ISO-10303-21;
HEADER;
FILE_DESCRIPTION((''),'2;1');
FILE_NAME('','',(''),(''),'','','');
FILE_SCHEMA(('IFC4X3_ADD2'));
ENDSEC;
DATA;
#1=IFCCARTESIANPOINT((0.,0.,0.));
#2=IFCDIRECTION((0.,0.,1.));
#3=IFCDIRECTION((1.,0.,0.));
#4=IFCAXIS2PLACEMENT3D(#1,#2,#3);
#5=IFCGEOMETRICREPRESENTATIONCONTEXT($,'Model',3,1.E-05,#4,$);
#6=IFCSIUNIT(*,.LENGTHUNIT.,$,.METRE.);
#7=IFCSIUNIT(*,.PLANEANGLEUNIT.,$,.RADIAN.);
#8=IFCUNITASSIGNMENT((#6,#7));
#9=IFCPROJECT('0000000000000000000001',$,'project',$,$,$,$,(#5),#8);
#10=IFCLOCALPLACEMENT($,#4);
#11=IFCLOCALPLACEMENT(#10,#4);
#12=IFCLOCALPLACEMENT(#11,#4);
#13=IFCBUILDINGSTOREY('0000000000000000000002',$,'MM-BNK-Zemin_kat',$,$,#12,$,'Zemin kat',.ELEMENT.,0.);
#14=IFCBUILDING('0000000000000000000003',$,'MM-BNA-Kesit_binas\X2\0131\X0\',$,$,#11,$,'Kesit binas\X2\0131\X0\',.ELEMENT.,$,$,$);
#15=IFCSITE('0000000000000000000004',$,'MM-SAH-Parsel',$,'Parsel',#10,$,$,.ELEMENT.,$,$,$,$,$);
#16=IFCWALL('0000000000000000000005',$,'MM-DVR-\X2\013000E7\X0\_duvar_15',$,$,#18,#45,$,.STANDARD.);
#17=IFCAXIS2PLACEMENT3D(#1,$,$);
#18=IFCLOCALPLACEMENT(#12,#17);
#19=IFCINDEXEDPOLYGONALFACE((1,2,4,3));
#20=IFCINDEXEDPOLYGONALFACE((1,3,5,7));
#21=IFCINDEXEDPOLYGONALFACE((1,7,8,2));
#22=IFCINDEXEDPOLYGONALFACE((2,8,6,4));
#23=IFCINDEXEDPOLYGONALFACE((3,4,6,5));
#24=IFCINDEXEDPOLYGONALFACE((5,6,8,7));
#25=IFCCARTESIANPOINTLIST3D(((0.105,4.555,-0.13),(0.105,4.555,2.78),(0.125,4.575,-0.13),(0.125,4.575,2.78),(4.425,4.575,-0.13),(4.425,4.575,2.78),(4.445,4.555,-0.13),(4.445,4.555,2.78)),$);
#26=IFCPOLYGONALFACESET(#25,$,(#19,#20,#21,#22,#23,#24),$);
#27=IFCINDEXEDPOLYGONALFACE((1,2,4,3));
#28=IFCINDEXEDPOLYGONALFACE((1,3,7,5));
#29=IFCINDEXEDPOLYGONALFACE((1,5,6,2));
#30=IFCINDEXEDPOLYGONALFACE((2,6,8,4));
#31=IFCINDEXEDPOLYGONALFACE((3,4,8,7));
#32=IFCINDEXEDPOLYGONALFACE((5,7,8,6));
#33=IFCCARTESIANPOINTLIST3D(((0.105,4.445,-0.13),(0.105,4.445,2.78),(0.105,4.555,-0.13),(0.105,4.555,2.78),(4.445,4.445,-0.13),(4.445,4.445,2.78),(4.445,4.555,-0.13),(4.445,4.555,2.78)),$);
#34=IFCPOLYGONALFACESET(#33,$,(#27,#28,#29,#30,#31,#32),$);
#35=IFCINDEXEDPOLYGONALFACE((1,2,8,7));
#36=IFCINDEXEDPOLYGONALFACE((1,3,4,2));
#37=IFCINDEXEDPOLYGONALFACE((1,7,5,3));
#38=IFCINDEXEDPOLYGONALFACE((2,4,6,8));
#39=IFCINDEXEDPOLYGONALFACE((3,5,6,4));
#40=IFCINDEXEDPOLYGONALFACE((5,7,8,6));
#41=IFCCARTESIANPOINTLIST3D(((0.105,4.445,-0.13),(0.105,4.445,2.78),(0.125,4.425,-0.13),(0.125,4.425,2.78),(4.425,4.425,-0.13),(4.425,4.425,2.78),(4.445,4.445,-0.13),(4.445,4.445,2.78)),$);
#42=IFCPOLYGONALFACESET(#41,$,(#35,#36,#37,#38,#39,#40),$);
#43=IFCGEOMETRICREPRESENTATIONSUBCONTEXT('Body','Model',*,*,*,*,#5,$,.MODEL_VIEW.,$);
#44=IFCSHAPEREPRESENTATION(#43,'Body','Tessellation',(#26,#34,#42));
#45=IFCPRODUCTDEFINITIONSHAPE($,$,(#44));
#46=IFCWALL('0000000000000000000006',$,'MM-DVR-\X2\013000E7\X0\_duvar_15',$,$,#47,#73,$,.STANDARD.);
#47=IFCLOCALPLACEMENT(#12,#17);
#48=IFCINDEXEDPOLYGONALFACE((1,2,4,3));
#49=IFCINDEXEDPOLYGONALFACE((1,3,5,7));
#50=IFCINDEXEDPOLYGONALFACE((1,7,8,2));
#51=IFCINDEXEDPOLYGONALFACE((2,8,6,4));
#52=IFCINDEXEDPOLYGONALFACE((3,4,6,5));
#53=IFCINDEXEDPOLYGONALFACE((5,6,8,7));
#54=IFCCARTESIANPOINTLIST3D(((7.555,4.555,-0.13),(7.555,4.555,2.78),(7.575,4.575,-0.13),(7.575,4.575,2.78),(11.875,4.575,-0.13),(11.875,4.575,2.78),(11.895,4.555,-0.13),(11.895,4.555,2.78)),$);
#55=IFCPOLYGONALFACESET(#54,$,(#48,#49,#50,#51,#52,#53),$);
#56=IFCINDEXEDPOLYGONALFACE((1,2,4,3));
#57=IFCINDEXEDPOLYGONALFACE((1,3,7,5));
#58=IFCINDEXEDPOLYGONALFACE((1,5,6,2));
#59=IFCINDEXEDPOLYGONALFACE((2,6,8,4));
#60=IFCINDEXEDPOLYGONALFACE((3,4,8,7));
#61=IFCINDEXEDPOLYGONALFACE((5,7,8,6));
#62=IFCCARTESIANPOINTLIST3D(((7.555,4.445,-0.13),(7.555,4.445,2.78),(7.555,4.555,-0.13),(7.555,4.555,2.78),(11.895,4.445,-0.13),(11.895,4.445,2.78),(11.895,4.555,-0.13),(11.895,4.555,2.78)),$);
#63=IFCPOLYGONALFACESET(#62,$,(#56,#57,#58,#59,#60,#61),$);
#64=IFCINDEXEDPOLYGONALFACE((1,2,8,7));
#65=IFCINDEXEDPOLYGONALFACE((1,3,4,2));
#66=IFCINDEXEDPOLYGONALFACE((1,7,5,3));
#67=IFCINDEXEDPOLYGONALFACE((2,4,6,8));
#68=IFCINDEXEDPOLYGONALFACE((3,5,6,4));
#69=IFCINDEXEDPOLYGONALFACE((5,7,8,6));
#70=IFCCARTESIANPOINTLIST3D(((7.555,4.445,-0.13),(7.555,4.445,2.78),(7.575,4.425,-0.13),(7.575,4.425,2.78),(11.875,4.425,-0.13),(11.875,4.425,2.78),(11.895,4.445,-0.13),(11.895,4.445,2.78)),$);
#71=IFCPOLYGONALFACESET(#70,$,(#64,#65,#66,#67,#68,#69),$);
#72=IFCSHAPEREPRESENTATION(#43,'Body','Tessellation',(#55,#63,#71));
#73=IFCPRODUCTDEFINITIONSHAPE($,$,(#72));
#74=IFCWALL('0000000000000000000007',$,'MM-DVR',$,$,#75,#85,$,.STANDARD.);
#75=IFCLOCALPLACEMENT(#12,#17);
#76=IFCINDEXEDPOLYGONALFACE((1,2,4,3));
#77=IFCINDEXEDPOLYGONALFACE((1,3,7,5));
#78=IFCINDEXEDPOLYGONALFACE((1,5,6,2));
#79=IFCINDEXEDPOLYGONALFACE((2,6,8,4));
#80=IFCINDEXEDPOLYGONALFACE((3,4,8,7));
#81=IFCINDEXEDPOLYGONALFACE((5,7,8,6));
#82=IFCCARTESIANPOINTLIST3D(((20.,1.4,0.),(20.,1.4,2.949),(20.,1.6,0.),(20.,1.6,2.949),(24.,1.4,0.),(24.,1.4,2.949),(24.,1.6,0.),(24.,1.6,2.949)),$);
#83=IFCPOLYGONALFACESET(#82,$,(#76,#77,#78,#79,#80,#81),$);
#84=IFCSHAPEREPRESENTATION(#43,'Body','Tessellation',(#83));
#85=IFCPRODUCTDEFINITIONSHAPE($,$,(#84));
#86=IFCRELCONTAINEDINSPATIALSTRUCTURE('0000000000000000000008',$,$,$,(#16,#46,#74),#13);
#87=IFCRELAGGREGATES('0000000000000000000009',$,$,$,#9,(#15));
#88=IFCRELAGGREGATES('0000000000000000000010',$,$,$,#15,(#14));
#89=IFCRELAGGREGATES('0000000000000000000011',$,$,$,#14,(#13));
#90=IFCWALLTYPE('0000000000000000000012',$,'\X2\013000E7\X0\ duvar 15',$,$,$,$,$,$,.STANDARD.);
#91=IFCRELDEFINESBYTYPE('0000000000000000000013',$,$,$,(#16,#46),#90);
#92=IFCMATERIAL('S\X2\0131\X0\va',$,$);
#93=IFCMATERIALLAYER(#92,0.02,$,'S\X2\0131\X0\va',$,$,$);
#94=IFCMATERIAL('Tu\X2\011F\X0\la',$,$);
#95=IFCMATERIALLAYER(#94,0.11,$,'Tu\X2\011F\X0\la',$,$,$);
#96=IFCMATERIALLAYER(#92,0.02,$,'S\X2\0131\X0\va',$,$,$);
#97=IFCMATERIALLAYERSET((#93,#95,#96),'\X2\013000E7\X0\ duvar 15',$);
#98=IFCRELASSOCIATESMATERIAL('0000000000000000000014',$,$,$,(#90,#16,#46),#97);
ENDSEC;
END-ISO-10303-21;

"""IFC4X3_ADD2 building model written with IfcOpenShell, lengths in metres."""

from ifc_helpers import new_model, si_unit, frame, origin, origin_with_axes, place, context, subcontext, project, spatial, polyline, outline, extrude, material, layer, layer_set, type_object, element, save


model = new_model("IFC4X3_ADD2")

# Units and contexts
model_context = context("Model", 3, precision=1e-05, world=origin_with_axes())
body_context = subcontext(model_context, "Body", "Model", "MODEL_VIEW")
ifc_project = project(units=[si_unit("LENGTHUNIT", "METRE"), si_unit("PLANEANGLEUNIT", "RADIAN")], contexts=[model_context])

# Site, building, storey
site_placement = place(None, origin_with_axes())
site = spatial("IfcSite", under=ifc_project, at=site_placement, Name="MM-SAH-Parsel", ObjectType="Parsel", CompositionType="ELEMENT")
building_placement = place(site_placement, origin_with_axes())
building = spatial("IfcBuilding", under=site, at=building_placement, Name="MM-BNA-Kesit_binası", LongName="Kesit binası", CompositionType="ELEMENT")
storey_placement = place(building_placement, origin_with_axes())
storey = spatial("IfcBuildingStorey", under=building, at=storey_placement, Name="MM-BNK-Zemin_kat", LongName="Zemin kat", CompositionType="ELEMENT", Elevation=0.0)

# Shared definitions
ifc_material_1 = material(Name="Tuğla")

# Shared definitions
ifc_material_2 = material(Name="Sıva")
ifc_layer_1 = layer(ifc_material_2, 0.02, Name="Sıva")
ifc_layer_2 = layer(ifc_material_1, 0.11, Name="Tuğla")
ifc_layer_3 = layer(ifc_material_2, 0.02, Name="Sıva")
ifc_layer_set_1 = layer_set([ifc_layer_1, ifc_layer_2, ifc_layer_3], Name="İç duvar 15")
wall_type_1 = type_object("IfcWallType", Name="İç duvar 15", PredefinedType="STANDARD", material=ifc_layer_set_1)

# Walls
wall_1_placement = place(storey_placement, origin_with_axes())
element("IfcWall", 1, at=wall_1_placement, inside=storey, type_object=wall_type_1, material=ifc_layer_set_1, Name="MM-DVR-İç_duvar_15", PredefinedType="STANDARD", context=body_context, shape_type="SweptSolid", body=[
    extrude(outline(polyline([(0.125, 4.575), (4.425, 4.575), (4.445, 4.555), (0.105, 4.555), (0.125, 4.575)])), frame((0.0, 0.0, -0.13)), (0.0, 0.0, 1.0), 2.91),
    extrude(outline(polyline([(0.105, 4.555), (4.445, 4.555), (4.445, 4.445), (0.105, 4.445), (0.105, 4.555)])), frame((0.0, 0.0, -0.13)), (0.0, 0.0, 1.0), 2.91),
    extrude(outline(polyline([(0.105, 4.445), (4.445, 4.445), (4.425, 4.425), (0.125, 4.425), (0.105, 4.445)])), frame((0.0, 0.0, -0.13)), (0.0, 0.0, 1.0), 2.91),
])
wall_2_placement = place(storey_placement, origin_with_axes())
element("IfcWall", 2, at=wall_2_placement, inside=storey, type_object=wall_type_1, material=ifc_layer_set_1, Name="MM-DVR-İç_duvar_15", PredefinedType="STANDARD", context=body_context, shape_type="SweptSolid", body=[
    extrude(outline(polyline([(7.575, 4.575), (11.875, 4.575), (11.895, 4.555), (7.555, 4.555), (7.575, 4.575)])), frame((0.0, 0.0, -0.13)), (0.0, 0.0, 1.0), 2.91),
    extrude(outline(polyline([(7.555, 4.555), (11.895, 4.555), (11.895, 4.445), (7.555, 4.445), (7.555, 4.555)])), frame((0.0, 0.0, -0.13)), (0.0, 0.0, 1.0), 2.91),
    extrude(outline(polyline([(7.555, 4.445), (11.895, 4.445), (11.875, 4.425), (7.575, 4.425), (7.555, 4.445)])), frame((0.0, 0.0, -0.13)), (0.0, 0.0, 1.0), 2.91),
])
wall_3_placement = place(storey_placement, origin_with_axes())
element("IfcWall", 3, at=wall_3_placement, inside=storey, Name="MM-DVR", PredefinedType="STANDARD", context=body_context, shape_type="SweptSolid", body=[
    extrude(outline(polyline([(20.0, 1.6), (24.0, 1.6), (24.0, 1.4), (20.0, 1.4), (20.0, 1.6)])), origin(), (0.0, 0.0, 1.0), 2.949),
])

save(model, "model.ifc")
